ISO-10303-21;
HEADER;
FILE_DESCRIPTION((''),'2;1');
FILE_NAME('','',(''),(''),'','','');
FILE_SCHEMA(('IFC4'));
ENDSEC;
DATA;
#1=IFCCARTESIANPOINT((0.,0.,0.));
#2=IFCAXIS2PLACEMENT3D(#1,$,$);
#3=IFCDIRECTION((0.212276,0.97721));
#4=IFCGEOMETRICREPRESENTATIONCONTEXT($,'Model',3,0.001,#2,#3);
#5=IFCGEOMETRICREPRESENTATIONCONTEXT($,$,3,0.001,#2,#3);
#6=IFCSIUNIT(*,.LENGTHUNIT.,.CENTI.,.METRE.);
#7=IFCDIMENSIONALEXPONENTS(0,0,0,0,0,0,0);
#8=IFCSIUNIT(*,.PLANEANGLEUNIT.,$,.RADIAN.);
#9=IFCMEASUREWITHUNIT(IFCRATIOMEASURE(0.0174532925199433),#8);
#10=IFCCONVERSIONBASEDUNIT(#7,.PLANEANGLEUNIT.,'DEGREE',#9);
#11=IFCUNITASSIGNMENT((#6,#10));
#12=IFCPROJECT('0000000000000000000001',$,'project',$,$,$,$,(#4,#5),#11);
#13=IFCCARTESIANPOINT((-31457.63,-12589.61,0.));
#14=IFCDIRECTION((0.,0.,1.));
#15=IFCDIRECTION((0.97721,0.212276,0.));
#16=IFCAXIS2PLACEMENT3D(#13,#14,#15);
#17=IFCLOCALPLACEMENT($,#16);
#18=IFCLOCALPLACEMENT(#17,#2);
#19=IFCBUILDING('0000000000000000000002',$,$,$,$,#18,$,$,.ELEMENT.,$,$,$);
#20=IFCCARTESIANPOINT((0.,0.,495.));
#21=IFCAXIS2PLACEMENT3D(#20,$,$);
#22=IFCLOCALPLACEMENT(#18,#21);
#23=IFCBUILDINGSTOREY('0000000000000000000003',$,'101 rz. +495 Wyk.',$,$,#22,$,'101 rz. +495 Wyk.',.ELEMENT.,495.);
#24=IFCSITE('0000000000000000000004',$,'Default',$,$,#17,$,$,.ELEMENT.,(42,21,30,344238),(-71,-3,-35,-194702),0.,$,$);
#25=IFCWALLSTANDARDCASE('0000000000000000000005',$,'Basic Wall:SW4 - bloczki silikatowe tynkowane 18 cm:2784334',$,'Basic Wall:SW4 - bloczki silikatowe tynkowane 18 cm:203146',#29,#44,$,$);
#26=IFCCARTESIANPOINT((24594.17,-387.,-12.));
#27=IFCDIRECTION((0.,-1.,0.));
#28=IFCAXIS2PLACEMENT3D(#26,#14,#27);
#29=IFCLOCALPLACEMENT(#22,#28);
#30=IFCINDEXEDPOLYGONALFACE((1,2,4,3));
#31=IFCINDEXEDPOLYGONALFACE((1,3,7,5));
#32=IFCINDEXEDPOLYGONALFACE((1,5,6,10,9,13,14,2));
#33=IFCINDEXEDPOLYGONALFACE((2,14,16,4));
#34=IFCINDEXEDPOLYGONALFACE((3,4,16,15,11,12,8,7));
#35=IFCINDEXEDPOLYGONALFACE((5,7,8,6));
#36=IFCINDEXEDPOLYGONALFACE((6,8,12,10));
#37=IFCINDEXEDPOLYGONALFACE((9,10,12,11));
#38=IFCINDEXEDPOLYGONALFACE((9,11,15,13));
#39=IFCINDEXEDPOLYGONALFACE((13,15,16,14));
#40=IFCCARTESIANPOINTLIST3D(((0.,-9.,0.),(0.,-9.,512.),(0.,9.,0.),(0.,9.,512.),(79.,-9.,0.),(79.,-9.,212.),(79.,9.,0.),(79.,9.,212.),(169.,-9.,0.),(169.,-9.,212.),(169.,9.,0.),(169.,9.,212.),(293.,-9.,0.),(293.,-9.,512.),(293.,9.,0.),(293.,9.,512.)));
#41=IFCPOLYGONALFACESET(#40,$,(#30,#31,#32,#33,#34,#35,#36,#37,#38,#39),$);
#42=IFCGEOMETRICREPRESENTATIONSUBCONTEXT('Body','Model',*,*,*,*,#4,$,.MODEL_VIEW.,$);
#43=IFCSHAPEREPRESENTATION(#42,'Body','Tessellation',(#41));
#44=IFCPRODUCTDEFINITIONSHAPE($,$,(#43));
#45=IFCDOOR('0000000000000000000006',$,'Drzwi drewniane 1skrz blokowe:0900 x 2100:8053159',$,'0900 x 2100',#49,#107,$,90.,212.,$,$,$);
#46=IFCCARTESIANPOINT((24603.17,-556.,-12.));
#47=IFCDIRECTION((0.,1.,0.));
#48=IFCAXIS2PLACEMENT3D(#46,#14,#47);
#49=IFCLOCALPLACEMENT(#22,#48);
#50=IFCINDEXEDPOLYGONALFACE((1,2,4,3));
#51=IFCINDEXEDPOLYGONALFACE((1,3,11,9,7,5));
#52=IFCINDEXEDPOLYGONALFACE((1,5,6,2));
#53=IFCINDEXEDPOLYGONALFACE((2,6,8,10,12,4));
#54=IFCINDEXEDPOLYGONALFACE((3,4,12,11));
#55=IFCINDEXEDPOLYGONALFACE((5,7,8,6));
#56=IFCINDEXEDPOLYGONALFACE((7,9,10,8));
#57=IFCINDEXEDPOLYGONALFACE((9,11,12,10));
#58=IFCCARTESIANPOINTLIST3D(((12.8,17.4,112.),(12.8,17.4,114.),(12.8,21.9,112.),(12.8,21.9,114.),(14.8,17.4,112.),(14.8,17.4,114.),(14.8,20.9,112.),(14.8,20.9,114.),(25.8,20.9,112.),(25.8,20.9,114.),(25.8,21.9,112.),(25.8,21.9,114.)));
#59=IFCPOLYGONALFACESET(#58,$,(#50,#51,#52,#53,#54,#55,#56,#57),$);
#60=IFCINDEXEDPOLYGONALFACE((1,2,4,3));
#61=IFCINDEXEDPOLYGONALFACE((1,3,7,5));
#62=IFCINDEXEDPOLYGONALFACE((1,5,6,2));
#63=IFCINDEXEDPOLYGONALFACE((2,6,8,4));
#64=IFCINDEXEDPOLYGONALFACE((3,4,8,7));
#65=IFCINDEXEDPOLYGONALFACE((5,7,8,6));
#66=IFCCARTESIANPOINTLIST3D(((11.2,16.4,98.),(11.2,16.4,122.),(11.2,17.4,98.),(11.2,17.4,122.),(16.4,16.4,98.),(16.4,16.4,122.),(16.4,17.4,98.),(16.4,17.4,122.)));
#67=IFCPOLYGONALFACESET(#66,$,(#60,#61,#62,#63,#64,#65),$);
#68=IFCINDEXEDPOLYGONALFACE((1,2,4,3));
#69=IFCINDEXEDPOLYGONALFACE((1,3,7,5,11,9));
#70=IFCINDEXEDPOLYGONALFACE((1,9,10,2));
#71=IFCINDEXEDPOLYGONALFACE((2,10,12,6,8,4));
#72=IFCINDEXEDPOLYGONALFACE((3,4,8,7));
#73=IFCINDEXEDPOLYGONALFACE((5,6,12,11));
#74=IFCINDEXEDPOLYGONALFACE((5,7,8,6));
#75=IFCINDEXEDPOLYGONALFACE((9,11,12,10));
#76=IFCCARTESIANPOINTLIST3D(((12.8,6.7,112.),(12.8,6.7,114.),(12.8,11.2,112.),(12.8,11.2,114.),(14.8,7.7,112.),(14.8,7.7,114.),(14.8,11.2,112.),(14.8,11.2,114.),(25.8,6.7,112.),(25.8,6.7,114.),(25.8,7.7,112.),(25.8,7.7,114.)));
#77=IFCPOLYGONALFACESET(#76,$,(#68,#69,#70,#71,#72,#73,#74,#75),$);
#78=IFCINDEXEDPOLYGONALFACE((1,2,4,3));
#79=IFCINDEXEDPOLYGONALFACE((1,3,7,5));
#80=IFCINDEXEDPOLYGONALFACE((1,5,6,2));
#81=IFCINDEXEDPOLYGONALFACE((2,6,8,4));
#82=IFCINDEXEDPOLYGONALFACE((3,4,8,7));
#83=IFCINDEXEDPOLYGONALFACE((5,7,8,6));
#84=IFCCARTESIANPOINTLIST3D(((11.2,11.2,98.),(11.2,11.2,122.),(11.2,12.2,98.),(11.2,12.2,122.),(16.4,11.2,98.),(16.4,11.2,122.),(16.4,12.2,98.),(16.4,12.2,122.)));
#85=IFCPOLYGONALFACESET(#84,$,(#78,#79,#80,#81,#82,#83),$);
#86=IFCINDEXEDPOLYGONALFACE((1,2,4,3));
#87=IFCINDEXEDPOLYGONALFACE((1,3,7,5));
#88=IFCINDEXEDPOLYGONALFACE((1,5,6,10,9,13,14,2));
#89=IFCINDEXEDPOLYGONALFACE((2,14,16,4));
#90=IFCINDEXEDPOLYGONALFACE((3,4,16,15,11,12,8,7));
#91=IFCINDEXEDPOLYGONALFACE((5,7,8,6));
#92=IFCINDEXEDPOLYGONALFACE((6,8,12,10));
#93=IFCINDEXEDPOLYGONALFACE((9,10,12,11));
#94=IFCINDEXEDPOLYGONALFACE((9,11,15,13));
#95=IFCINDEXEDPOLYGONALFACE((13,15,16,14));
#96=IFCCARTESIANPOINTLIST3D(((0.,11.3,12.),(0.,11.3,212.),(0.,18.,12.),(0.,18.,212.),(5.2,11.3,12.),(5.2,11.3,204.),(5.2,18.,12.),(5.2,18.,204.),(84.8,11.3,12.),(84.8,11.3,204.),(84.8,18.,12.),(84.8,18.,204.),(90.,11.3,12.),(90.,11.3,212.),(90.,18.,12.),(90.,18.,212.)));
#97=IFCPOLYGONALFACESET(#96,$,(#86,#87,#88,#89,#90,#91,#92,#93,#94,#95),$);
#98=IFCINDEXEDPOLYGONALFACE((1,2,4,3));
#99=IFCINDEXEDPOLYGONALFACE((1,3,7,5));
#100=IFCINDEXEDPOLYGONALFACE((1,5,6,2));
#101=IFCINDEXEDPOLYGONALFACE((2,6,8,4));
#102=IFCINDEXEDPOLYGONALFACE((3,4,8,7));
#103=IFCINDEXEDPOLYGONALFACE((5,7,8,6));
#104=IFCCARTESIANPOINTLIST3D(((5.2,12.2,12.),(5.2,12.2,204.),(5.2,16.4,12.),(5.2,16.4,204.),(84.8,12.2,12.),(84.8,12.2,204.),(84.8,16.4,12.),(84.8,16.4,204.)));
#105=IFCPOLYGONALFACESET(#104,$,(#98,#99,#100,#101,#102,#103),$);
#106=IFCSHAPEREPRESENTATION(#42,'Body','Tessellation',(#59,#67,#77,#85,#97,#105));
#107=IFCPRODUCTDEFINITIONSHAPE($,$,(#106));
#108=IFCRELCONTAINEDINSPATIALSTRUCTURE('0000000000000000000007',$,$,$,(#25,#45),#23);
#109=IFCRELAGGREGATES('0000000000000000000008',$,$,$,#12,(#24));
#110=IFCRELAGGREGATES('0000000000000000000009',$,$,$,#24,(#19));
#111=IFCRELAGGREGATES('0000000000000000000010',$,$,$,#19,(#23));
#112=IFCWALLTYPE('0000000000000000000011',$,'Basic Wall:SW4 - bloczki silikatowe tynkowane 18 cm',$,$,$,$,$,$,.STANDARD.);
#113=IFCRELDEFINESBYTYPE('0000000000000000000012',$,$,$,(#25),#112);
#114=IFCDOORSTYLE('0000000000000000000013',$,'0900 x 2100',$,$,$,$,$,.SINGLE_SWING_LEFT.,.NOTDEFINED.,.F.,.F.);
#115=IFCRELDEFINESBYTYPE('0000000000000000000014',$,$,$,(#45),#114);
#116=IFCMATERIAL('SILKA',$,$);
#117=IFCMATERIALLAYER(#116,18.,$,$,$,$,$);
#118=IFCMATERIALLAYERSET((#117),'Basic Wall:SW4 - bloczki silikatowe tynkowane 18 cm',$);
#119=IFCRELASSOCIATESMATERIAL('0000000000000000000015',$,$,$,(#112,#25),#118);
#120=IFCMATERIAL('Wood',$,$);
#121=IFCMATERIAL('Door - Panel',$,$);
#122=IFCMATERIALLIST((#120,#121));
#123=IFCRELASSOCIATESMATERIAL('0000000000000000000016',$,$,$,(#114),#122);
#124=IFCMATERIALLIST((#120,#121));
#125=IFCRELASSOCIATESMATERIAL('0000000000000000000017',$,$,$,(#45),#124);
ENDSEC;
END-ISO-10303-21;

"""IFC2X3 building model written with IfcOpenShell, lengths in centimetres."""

from ifc_helpers import new_model, entity, si_unit, converted_unit, direction, frame, frame_2d, origin, place, context, subcontext, project, spatial, polyline, rectangle, outline, extrude, clip, bounded_halfspace, source, transform, mapped, material, material_list, layer, layer_set, layer_usage, type_object, type_shapes, element, fill, save


model = new_model("IFC2X3")

# Units and contexts
model_context = context("Model", 3, precision=0.001, world=origin(), true_north=direction((0.212276, 0.97721)))
context_of_model = context(None, 3, precision=0.001, world=origin(), true_north=direction((0.212276, 0.97721)))
body_context = subcontext(model_context, "Body", "Model", "MODEL_VIEW")
ifc_project = project(units=[si_unit("LENGTHUNIT", "METRE", prefix="CENTI"), converted_unit("PLANEANGLEUNIT", "DEGREE", entity("IfcRatioMeasure", 0.0174532925199433), si_unit("PLANEANGLEUNIT", "RADIAN"), dimensions=[0, 0, 0, 0, 0, 0, 0])], contexts=[model_context, context_of_model])

# Site, building, storey
site_placement = place(None, frame((-31457.63, -12589.61, 0.0), z_axis=(0.0, 0.0, 1.0), x_axis=(0.97721, 0.212276, 0.0)))
site = spatial("IfcSite", under=ifc_project, at=site_placement, Name="Default", CompositionType="ELEMENT", RefLatitude=(42, 21, 30, 344238), RefLongitude=(-71, -3, -35, -194702), RefElevation=0.0)
building_placement = place(site_placement, origin())
building = spatial("IfcBuilding", under=site, at=building_placement, CompositionType="ELEMENT")
storey_placement = place(building_placement, frame((0.0, 0.0, 495.0)))
storey = spatial("IfcBuildingStorey", under=building, at=storey_placement, Name="101 rz. +495 Wyk.", LongName="101 rz. +495 Wyk.", CompositionType="ELEMENT", Elevation=495.0)

# Shared definitions
ifc_material_1 = material(Name="SILKA")
ifc_layer_1 = layer(ifc_material_1, 18.0)
ifc_layer_set_1 = layer_set([ifc_layer_1], Name="Basic Wall:SW4 - bloczki silikatowe tynkowane 18 cm")
wall_type_1 = type_object("IfcWallType", Name="Basic Wall:SW4 - bloczki silikatowe tynkowane 18 cm", PredefinedType="STANDARD", material=ifc_layer_set_1)

# Shared definitions
ifc_material_2 = material(Name="Door - Panel")
ifc_material_3 = material(Name="Wood")

# Wall, opening, door
ifc_layer_usage_1 = layer_usage(ifc_layer_set_1, "AXIS2", "NEGATIVE", 9.0)
wall_1_placement = place(storey_placement, frame((24594.17, -387.0, -12.0), z_axis=(0.0, 0.0, 1.0), x_axis=(0.0, -1.0, 0.0)))
wall_1 = element("IfcWallStandardCase", 1, at=wall_1_placement, inside=storey, type_object=wall_type_1, material=ifc_layer_usage_1, Name="Basic Wall:SW4 - bloczki silikatowe tynkowane 18 cm:2784334", ObjectType="Basic Wall:SW4 - bloczki silikatowe tynkowane 18 cm:203146", context=body_context, shape_type="Clipping", body=[
    clip(extrude(rectangle(XDim=293.0, YDim=18.0, at=frame_2d((146.5, 0.0), x_axis=(-1.0, 0.0))), origin(), (0.0, 0.0, 1.0), 537.0), bounded_halfspace(frame((0.0, -9.0, 512.0), z_axis=(0.0, 0.0, -1.0), x_axis=(0.0, 1.0, 0.0)), True, frame((0.0, -9.0, 512.0)), polyline([(0.0, 0.0), (48.0, 0.0), (66.0, 0.0), (251.0, 0.0), (269.0, 0.0), (275.0, 0.0), (293.0, 0.0), (293.0, 18.0), (187.0, 18.0), (169.0, 18.0), (8.0, 18.0), (0.0, 18.0), (0.0, 0.0)]))),
])
opening_1_placement = place(wall_1_placement, frame((169.0, -9.0, 0.0), z_axis=(0.0, 0.0, 1.0), x_axis=(0.0, 1.0, 0.0)))
opening_1 = element("IfcOpeningElement", 2, at=opening_1_placement, cuts=wall_1, ObjectType="Opening", context=body_context, shape_type="SweptSolid", body=[
    extrude(rectangle(XDim=212.0, YDim=90.0, at=frame_2d((0.0, 0.0), x_axis=(1.0, 0.0))), frame((0.0, 45.0, 106.0), z_axis=(1.0, 0.0, 0.0), x_axis=(0.0, 0.0, -1.0)), (0.0, 0.0, 1.0), 18.0),
])
ifc_material_list_1 = material_list([ifc_material_3, ifc_material_2])
ifc_material_list_2 = material_list([ifc_material_3, ifc_material_2])
door_style_1 = type_object("IfcDoorStyle", Name="0900 x 2100", ConstructionType="NOTDEFINED", OperationType="SINGLE_SWING_LEFT", ParameterTakesPrecedence=False, Sizeable=False, material=ifc_material_list_2)
shared_shape_1 = source(origin(), body_context, "Body", "SweptSolid", [
    extrude(outline(polyline([(-1.83, -5.0), (2.67, -5.0), (2.67, -3.0), (-0.83, -3.0), (-0.83, 8.0), (-1.83, 8.0), (-1.83, -5.0)])), frame((17.8, 20.07, 112.0), z_axis=(0.0, 0.0, 1.0), x_axis=(0.0, -1.0, 0.0)), (0.0, 0.0, 1.0), 2.0),
    extrude(rectangle(XDim=5.2, YDim=1.0, at=frame_2d((0.0, 0.0), x_axis=(1.0, 0.0))), frame((13.8, 16.9, 98.0), z_axis=(0.0, 0.0, 1.0), x_axis=(-1.0, 0.0, 0.0)), (0.0, 0.0, 1.0), 24.0),
    extrude(outline(polyline([(-5.0, -1.83), (8.0, -1.83), (8.0, -0.83), (-3.0, -0.83), (-3.0, 2.67), (-5.0, 2.67), (-5.0, -1.83)])), frame((17.8, 8.53, 112.0)), (0.0, 0.0, 1.0), 2.0),
    extrude(rectangle(XDim=1.0, YDim=5.2, at=frame_2d((0.0, 0.0), x_axis=(1.0, 0.0))), frame((13.8, 11.7, 98.0), z_axis=(0.0, 0.0, 1.0), x_axis=(0.0, 1.0, 0.0)), (0.0, 0.0, 1.0), 24.0),
    extrude(outline(polyline([(-102.0, -45.0), (98.0, -45.0), (98.0, -39.8), (-94.0, -39.8), (-94.0, 39.8), (98.0, 39.8), (98.0, 45.0), (-102.0, 45.0), (-102.0, -45.0)])), frame((45.0, 11.3, 110.0), z_axis=(0.0, 1.0, 0.0), x_axis=(0.0, 0.0, -1.0)), (0.0, 0.0, 1.0), 6.7),
    extrude(rectangle(XDim=4.2, YDim=79.6, at=frame_2d((0.0, 0.0), x_axis=(1.0, 0.0))), frame((45.0, 14.3, 12.0), z_axis=(0.0, 0.0, 1.0), x_axis=(0.0, 1.0, 0.0)), (0.0, 0.0, 1.0), 192.0),
])
type_shapes(door_style_1, [shared_shape_1])
door_1_placement = place(storey_placement, frame((24603.17, -556.0, -12.0), z_axis=(0.0, 0.0, 1.0), x_axis=(0.0, 1.0, 0.0)))
door_1 = element("IfcDoor", 3, at=door_1_placement, inside=storey, type_object=door_style_1, material=ifc_material_list_1, Name="Drzwi drewniane 1skrz blokowe:0900 x 2100:8053159", ObjectType="0900 x 2100", OverallHeight=90.0, OverallWidth=212.0, context=body_context, shape_type="MappedRepresentation", body=[
    mapped(shared_shape_1, transform((0.0, 0.0, 0.0), scale=1.0)),
])
fill(opening_1, door_1)

save(model, "model.ifc")
